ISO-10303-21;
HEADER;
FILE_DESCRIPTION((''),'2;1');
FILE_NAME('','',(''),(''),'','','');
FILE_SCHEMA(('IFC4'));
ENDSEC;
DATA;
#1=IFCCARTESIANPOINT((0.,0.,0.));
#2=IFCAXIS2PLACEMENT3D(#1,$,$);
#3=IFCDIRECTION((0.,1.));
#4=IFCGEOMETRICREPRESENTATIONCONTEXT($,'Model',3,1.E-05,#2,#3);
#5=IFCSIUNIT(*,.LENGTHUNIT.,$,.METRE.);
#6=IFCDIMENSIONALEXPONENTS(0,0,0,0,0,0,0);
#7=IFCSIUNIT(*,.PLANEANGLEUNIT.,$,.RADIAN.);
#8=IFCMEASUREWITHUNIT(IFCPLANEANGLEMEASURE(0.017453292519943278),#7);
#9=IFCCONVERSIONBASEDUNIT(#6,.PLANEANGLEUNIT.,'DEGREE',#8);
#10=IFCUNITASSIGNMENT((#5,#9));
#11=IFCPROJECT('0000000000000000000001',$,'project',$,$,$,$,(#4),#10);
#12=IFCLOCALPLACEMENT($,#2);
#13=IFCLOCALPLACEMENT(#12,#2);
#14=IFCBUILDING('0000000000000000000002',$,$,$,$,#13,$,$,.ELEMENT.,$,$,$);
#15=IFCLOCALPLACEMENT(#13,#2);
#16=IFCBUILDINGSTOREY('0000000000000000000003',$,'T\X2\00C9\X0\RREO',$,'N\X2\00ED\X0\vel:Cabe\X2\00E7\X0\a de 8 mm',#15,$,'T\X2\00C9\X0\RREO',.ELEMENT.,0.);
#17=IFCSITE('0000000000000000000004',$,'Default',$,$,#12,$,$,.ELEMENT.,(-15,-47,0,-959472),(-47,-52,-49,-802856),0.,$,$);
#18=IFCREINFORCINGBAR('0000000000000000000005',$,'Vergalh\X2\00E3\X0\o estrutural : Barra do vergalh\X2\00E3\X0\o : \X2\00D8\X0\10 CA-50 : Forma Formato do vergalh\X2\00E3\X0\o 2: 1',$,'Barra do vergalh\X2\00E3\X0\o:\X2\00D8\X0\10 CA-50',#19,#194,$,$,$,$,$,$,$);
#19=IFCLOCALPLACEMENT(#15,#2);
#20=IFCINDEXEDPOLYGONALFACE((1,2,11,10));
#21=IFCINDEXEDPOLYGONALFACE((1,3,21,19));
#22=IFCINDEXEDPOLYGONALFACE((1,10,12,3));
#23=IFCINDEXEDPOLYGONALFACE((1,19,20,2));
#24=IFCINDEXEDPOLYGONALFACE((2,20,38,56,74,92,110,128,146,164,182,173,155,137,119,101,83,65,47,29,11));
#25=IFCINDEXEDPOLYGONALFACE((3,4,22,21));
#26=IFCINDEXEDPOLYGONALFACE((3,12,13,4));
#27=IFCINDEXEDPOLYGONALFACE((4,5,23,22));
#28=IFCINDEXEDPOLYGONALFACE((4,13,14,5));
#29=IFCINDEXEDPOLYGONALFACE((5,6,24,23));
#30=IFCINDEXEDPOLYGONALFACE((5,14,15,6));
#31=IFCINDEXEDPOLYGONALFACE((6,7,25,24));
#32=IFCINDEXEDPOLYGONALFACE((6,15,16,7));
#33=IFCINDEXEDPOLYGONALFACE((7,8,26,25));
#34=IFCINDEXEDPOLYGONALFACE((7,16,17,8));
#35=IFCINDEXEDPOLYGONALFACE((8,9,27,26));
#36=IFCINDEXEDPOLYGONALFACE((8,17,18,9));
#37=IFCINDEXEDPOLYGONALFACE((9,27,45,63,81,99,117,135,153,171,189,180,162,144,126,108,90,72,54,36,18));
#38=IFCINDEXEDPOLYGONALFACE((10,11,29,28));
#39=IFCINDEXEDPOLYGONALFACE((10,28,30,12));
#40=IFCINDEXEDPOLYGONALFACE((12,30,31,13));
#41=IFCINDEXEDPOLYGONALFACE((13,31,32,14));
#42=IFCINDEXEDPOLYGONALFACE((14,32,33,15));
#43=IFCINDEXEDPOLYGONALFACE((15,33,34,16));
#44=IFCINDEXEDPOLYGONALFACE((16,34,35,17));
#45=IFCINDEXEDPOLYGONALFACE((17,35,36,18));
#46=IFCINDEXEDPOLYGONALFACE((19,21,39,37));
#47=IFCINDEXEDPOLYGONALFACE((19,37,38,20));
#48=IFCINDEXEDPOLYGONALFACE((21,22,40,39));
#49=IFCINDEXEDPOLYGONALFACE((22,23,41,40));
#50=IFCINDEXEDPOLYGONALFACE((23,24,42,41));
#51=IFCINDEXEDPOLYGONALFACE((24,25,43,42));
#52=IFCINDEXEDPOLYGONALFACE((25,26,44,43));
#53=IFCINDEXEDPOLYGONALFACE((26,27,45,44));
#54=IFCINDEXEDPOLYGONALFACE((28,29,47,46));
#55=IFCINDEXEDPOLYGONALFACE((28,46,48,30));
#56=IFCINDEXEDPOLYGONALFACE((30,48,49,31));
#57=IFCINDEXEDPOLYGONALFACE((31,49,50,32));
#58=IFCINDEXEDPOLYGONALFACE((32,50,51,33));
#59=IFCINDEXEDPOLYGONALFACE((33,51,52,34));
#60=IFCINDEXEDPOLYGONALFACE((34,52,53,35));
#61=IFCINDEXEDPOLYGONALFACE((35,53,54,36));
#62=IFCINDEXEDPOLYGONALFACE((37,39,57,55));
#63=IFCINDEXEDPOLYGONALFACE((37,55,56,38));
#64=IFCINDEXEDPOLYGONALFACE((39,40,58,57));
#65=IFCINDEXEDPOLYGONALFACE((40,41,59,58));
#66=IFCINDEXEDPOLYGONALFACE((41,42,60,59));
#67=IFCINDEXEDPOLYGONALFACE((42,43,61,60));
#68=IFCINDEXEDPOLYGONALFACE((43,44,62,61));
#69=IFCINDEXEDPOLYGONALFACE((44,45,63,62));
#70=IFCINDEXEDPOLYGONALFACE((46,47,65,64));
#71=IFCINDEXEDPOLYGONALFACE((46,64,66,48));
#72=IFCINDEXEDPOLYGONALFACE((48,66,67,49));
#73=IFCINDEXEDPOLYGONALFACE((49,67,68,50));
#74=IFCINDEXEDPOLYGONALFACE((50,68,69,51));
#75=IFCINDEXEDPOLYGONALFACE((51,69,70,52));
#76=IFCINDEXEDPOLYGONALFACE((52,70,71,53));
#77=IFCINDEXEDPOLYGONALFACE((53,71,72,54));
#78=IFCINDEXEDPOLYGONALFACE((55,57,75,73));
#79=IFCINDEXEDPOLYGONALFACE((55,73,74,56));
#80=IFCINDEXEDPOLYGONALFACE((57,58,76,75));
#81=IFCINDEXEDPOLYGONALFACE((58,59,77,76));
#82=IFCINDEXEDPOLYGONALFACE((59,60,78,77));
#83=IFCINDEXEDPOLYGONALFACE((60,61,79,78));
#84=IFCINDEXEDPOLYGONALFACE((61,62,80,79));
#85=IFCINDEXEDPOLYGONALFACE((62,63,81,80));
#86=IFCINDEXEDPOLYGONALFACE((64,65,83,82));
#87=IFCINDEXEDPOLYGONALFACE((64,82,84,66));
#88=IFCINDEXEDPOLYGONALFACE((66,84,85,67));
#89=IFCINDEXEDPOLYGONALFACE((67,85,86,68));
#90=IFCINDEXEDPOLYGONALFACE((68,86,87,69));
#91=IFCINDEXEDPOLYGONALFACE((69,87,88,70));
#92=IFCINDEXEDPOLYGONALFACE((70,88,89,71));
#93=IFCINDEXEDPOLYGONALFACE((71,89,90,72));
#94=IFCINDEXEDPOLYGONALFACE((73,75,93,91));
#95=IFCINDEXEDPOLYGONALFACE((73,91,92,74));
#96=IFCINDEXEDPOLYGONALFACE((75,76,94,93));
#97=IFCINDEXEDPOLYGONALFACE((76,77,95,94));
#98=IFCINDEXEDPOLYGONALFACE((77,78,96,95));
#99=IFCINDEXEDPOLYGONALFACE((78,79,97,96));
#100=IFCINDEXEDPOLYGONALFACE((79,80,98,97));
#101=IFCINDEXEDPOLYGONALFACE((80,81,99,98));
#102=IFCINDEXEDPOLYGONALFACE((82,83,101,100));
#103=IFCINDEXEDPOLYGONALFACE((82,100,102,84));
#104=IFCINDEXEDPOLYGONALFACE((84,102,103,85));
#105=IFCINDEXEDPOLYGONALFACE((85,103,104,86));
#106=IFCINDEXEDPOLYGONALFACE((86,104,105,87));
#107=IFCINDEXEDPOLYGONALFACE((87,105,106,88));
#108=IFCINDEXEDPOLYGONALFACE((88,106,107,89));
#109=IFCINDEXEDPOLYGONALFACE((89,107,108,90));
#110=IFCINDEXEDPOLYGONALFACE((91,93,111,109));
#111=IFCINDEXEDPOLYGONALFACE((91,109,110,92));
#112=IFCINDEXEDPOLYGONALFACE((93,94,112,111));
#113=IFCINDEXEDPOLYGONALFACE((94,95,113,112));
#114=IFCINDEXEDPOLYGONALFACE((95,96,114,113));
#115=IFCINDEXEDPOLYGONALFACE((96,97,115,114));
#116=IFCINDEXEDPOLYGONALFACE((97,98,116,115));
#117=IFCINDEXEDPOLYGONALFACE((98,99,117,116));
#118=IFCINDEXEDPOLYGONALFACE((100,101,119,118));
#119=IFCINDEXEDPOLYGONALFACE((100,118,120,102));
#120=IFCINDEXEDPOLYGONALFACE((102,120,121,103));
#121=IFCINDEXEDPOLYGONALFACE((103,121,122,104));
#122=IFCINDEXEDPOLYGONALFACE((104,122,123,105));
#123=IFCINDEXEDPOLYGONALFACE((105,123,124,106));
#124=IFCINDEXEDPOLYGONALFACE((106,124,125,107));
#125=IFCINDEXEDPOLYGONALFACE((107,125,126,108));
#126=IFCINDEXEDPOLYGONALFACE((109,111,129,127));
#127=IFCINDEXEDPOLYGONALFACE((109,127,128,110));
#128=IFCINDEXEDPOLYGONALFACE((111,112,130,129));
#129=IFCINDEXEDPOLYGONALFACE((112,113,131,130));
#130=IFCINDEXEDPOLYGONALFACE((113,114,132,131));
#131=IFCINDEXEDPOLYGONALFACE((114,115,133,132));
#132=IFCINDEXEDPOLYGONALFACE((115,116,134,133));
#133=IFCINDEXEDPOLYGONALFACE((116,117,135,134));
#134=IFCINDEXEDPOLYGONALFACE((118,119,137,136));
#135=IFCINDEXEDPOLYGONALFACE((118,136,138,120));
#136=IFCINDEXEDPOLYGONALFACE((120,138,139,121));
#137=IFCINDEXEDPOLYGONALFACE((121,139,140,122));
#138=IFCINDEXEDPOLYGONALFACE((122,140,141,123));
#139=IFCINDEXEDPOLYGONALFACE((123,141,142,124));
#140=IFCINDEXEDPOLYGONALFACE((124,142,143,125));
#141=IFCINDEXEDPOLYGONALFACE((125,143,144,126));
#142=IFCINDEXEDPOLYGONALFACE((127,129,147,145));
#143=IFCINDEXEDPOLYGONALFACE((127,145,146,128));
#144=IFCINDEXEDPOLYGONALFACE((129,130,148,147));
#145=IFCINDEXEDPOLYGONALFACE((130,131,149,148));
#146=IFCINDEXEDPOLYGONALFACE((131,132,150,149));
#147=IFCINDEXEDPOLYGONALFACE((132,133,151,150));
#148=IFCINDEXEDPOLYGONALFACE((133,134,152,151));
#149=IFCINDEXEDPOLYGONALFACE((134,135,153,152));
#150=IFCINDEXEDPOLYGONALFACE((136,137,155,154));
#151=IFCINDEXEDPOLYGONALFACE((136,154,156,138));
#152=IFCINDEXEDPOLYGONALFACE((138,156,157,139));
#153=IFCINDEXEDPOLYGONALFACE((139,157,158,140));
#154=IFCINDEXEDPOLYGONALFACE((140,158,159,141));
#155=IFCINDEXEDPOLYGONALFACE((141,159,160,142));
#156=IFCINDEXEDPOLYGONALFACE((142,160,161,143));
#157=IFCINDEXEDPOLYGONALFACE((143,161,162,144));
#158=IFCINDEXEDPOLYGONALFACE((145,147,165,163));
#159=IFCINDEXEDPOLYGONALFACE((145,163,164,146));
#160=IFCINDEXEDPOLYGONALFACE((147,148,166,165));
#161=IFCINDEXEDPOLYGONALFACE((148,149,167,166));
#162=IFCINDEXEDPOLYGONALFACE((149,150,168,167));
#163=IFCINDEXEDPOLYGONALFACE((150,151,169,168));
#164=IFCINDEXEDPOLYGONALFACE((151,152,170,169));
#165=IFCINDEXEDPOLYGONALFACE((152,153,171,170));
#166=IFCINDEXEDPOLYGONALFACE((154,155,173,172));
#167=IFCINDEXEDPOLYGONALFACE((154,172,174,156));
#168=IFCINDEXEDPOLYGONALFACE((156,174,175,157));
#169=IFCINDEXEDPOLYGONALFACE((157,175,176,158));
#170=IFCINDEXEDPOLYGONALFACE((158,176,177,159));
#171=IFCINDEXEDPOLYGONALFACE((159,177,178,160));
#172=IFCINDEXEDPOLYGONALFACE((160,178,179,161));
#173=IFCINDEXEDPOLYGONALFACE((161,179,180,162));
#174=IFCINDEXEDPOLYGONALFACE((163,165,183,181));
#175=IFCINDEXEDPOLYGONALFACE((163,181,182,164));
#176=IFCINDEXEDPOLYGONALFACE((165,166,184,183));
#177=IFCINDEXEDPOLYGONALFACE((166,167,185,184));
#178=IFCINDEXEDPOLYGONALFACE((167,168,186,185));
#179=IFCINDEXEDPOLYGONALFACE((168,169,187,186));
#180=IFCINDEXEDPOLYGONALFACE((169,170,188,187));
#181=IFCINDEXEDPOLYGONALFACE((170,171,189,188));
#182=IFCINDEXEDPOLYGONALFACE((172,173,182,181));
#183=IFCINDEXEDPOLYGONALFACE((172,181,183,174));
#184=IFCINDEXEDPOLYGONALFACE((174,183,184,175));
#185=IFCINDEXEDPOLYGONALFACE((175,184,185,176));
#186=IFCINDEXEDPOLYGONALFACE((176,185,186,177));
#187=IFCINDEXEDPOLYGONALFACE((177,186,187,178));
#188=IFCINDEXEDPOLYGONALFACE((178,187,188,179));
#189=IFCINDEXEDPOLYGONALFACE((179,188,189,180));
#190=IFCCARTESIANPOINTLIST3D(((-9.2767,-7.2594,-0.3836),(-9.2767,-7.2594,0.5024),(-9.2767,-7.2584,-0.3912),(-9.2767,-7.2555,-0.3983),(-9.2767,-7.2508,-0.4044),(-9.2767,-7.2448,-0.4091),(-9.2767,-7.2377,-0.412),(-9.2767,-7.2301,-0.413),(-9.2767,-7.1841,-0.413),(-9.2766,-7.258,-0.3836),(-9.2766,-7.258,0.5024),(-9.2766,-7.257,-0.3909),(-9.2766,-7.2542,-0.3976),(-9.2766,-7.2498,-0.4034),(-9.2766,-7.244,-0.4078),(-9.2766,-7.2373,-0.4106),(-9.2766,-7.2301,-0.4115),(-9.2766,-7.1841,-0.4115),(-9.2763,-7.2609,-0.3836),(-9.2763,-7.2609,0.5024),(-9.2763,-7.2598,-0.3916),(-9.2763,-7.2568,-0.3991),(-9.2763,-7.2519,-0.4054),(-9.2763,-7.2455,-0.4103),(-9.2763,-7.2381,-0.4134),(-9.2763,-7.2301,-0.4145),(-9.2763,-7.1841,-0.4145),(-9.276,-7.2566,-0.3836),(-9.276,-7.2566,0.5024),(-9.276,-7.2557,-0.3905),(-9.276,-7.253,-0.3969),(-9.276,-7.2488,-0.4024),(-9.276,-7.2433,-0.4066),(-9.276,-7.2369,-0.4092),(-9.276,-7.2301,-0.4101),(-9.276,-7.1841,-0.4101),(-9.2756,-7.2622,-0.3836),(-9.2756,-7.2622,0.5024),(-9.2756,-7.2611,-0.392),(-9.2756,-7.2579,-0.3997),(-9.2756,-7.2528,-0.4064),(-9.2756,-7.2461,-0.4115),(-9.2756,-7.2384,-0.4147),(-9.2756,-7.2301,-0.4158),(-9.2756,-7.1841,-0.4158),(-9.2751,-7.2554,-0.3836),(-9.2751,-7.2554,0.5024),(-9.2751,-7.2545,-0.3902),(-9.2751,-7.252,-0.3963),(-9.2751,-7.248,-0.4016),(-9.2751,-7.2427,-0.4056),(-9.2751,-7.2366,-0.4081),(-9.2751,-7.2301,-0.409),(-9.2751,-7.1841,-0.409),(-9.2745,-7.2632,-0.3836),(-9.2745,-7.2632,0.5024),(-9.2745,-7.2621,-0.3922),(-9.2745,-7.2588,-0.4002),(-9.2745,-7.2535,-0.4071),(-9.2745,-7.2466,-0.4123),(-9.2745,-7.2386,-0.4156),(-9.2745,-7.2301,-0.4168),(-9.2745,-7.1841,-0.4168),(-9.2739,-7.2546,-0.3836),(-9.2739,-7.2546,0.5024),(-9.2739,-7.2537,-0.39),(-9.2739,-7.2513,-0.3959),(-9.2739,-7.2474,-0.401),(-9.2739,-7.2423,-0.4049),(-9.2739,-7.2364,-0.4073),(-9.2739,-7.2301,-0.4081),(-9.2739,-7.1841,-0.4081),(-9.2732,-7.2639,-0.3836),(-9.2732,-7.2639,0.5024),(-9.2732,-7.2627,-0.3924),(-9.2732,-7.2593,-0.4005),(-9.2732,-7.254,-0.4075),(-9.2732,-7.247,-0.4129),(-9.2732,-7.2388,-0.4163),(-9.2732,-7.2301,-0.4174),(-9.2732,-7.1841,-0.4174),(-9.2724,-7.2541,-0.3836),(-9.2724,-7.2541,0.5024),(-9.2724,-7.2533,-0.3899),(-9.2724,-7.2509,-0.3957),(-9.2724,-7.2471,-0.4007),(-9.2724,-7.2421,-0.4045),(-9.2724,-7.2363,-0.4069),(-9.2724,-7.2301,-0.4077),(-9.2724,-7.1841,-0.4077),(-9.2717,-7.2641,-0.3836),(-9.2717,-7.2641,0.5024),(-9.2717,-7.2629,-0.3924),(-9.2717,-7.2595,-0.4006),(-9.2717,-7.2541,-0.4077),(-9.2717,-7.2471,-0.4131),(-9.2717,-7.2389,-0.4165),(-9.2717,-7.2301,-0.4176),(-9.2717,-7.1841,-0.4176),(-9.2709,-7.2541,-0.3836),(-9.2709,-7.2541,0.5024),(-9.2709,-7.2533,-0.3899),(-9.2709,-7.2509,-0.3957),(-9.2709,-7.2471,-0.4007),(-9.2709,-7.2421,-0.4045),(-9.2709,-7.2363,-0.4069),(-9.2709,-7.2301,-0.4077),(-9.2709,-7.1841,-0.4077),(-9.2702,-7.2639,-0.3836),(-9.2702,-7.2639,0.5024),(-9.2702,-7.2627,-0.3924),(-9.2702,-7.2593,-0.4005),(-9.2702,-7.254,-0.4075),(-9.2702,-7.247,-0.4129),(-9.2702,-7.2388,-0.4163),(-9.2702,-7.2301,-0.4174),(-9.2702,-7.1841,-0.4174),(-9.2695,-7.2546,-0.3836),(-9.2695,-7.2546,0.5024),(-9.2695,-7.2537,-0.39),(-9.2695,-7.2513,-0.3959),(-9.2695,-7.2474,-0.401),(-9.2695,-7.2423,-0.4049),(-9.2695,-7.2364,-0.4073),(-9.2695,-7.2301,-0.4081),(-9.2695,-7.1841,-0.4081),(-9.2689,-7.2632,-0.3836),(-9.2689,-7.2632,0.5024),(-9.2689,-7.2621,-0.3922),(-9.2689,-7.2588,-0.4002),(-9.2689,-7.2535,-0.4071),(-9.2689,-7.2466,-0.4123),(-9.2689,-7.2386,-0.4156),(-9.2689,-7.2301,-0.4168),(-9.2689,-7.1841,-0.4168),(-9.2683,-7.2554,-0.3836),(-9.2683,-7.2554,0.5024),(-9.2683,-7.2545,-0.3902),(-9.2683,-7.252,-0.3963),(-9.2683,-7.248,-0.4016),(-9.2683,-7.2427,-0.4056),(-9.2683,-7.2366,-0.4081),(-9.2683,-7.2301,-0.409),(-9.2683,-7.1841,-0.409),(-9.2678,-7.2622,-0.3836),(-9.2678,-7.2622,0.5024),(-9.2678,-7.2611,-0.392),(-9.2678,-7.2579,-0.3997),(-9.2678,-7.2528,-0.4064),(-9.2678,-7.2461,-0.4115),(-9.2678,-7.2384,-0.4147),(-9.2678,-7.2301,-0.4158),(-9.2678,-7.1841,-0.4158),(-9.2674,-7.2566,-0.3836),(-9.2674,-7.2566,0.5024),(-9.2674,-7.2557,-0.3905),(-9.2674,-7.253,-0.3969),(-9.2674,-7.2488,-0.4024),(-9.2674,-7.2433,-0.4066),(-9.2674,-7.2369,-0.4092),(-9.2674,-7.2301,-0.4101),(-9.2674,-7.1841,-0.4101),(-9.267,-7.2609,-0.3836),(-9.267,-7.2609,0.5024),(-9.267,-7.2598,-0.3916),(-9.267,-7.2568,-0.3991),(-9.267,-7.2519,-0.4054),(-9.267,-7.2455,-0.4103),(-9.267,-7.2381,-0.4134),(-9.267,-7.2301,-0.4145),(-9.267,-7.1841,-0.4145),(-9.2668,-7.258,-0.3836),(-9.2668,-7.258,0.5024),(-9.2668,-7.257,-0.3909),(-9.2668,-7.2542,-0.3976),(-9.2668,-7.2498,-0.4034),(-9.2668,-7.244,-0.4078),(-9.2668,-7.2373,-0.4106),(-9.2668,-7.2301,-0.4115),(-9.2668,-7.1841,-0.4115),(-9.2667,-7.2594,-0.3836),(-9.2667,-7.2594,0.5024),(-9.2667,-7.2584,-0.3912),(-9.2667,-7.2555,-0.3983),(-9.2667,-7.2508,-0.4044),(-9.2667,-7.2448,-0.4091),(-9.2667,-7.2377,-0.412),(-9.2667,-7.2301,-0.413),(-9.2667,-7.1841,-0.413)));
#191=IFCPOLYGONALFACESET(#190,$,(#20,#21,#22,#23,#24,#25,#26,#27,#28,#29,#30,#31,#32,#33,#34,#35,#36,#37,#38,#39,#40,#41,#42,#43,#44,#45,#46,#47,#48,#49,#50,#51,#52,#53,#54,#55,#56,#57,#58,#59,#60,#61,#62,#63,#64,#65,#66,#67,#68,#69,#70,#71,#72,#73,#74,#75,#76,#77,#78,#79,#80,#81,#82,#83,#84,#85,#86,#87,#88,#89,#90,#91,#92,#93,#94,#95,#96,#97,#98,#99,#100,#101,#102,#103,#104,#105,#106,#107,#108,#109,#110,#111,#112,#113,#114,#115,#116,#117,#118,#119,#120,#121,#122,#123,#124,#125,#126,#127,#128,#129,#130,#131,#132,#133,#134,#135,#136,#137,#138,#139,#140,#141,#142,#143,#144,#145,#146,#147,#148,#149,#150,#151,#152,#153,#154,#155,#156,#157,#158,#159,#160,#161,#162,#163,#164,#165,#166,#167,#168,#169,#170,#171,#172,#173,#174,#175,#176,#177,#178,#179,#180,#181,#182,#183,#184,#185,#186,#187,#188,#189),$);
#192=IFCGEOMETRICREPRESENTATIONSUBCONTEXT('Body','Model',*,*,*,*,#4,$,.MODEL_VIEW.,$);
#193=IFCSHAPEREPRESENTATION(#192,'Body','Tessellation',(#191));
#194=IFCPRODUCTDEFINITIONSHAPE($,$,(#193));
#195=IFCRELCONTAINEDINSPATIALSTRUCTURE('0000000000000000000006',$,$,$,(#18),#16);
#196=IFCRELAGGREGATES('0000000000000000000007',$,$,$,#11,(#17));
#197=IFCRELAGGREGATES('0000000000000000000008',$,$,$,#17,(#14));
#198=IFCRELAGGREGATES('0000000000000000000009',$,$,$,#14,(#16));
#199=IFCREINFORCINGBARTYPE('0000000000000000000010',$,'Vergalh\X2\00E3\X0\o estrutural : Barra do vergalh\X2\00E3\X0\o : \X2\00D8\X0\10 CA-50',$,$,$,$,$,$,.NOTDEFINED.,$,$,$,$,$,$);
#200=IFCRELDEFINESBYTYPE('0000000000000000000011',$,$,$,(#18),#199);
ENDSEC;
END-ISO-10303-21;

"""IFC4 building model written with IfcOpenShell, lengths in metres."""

from ifc_helpers import new_model, entity, si_unit, converted_unit, direction, origin, place, context, subcontext, project, spatial, type_object, element, save


model = new_model("IFC4")

# Units and contexts
model_context = context("Model", 3, precision=1e-05, world=origin(), true_north=direction((0.0, 1.0)))
body_context = subcontext(model_context, "Body", "Model", "MODEL_VIEW")
ifc_project = project(units=[si_unit("LENGTHUNIT", "METRE"), converted_unit("PLANEANGLEUNIT", "DEGREE", entity("IfcPlaneAngleMeasure", 0.017453292519943278), si_unit("PLANEANGLEUNIT", "RADIAN"), dimensions=[0, 0, 0, 0, 0, 0, 0])], contexts=[model_context])

# Site, building, storey
site_placement = place(None, origin())
site = spatial("IfcSite", under=ifc_project, at=site_placement, Name="Default", CompositionType="ELEMENT", RefLatitude=(-15, -47, 0, -959472), RefLongitude=(-47, -52, -49, -802856), RefElevation=0.0)
building_placement = place(site_placement, origin())
building = spatial("IfcBuilding", under=site, at=building_placement, CompositionType="ELEMENT")
storey_placement = place(building_placement, origin())
storey = spatial("IfcBuildingStorey", under=building, at=storey_placement, Name="TÉRREO", ObjectType="Nível:Cabeça de 8 mm", LongName="TÉRREO", CompositionType="ELEMENT", Elevation=0.0)

# Reinforcing bar
reinforcing_bar_type_1 = type_object("IfcReinforcingBarType", Name="Vergalhão estrutural : Barra do vergalhão : Ø10 CA-50", PredefinedType="NOTDEFINED")
reinforcing_bar_1_placement = place(storey_placement, origin())
element("IfcReinforcingBar", 1, at=reinforcing_bar_1_placement, inside=storey, type_object=reinforcing_bar_type_1, Name="Vergalhão estrutural : Barra do vergalhão : Ø10 CA-50 : Forma Formato do vergalhão 2: 1", ObjectType="Barra do vergalhão:Ø10 CA-50", context=body_context, shape_type="AdvancedSweptSolid", body=[
    entity("IfcSweptDiskSolid", entity("IfcIndexedPolyCurve", entity("IfcCartesianPointList3D", [[-9.2717, -7.1841, -0.4126], [-9.2717, -7.2301, -0.4126], [-9.2717, -7.2506, -0.4042], [-9.2717, -7.2591, -0.3836], [-9.2717, -7.2591, 0.5024]]), [entity("IfcLineIndex", [1, 2]), entity("IfcArcIndex", [2, 3, 4]), entity("IfcLineIndex", [4, 5])], False), 0.005, None, 0.0, 92.0),
])

save(model, "model.ifc")
